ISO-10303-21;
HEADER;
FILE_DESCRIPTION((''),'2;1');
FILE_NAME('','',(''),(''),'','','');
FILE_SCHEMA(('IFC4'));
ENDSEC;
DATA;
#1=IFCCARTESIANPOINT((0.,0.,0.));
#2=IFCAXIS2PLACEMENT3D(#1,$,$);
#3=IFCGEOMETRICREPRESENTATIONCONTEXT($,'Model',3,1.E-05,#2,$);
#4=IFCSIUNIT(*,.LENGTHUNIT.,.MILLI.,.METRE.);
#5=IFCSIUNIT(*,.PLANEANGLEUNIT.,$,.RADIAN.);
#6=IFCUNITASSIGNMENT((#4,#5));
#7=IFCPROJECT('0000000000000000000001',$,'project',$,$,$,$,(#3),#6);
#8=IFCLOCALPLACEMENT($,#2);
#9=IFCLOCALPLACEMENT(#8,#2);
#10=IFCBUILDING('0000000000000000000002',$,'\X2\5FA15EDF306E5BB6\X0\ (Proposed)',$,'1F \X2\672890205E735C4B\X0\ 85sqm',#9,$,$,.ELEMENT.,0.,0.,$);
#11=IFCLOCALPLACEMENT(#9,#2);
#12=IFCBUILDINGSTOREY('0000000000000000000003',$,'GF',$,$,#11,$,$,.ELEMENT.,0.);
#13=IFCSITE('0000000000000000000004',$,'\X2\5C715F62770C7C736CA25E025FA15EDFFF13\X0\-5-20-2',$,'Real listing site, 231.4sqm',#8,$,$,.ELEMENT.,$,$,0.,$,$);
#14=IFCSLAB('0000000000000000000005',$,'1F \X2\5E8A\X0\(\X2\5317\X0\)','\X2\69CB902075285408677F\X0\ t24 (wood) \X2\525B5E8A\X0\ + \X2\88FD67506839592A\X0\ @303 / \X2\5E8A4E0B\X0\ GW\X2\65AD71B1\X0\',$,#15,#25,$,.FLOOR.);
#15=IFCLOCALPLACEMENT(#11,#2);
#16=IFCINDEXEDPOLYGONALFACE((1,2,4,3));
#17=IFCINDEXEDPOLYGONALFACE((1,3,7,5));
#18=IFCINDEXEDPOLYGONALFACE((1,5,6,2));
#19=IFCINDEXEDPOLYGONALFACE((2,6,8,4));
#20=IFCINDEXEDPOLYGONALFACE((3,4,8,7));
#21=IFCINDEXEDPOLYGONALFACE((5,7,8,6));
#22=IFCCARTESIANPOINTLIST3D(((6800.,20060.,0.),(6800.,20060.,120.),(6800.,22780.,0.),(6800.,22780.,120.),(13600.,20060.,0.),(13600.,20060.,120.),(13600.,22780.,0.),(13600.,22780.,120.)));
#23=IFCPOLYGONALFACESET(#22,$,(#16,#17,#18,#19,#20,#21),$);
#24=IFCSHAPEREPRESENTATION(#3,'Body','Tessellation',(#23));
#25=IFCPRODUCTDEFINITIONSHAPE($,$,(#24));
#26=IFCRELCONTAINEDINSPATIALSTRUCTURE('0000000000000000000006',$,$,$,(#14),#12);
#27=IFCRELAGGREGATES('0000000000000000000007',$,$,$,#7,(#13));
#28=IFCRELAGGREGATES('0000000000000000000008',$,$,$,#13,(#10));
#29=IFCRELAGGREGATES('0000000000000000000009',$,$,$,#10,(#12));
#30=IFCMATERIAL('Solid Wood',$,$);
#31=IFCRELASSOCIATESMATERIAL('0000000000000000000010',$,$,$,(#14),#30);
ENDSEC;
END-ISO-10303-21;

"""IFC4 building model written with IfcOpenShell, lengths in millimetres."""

from ifc_helpers import new_model, si_unit, frame, frame_2d, origin, place, context, project, spatial, rectangle, extrude, material, element, save


model = new_model("IFC4")

# Units and contexts
model_context = context("Model", 3, precision=1e-05, world=origin())
ifc_project = project(units=[si_unit("LENGTHUNIT", "METRE", prefix="MILLI"), si_unit("PLANEANGLEUNIT", "RADIAN")], contexts=[model_context])

# Site, building, storey
site_placement = place(None, origin())
site = spatial("IfcSite", under=ifc_project, at=site_placement, Name="山形県米沢市御廟３-5-20-2", ObjectType="Real listing site, 231.4sqm", CompositionType="ELEMENT", RefElevation=0.0)
building_placement = place(site_placement, origin())
building = spatial("IfcBuilding", under=site, at=building_placement, Name="御廟の家 (Proposed)", ObjectType="1F 木造平屋 85sqm", CompositionType="ELEMENT", ElevationOfRefHeight=0.0, ElevationOfTerrain=0.0)
storey_placement = place(building_placement, origin())
storey = spatial("IfcBuildingStorey", under=building, at=storey_placement, Name="GF", CompositionType="ELEMENT", Elevation=0.0)

# Slab
ifc_material_1 = material(Name="Solid Wood")
slab_1_placement = place(storey_placement, frame((3400.0, 10030.0, 0.0)))
element("IfcSlab", 1, at=slab_1_placement, inside=storey, material=ifc_material_1, Name="1F 床(北)", Description="構造用合板 t24 (wood) 剛床 + 製材根太 @303 / 床下 GW断熱", PredefinedType="FLOOR", context=model_context, shape_type="SweptSolid", body=[
    extrude(rectangle(XDim=6800.0, YDim=2720.0, at=frame_2d((3400.0, 1360.0))), frame((3400.0, 10030.0, 0.0)), (0.0, 0.0, 1.0), 120.0),
])

save(model, "model.ifc")
